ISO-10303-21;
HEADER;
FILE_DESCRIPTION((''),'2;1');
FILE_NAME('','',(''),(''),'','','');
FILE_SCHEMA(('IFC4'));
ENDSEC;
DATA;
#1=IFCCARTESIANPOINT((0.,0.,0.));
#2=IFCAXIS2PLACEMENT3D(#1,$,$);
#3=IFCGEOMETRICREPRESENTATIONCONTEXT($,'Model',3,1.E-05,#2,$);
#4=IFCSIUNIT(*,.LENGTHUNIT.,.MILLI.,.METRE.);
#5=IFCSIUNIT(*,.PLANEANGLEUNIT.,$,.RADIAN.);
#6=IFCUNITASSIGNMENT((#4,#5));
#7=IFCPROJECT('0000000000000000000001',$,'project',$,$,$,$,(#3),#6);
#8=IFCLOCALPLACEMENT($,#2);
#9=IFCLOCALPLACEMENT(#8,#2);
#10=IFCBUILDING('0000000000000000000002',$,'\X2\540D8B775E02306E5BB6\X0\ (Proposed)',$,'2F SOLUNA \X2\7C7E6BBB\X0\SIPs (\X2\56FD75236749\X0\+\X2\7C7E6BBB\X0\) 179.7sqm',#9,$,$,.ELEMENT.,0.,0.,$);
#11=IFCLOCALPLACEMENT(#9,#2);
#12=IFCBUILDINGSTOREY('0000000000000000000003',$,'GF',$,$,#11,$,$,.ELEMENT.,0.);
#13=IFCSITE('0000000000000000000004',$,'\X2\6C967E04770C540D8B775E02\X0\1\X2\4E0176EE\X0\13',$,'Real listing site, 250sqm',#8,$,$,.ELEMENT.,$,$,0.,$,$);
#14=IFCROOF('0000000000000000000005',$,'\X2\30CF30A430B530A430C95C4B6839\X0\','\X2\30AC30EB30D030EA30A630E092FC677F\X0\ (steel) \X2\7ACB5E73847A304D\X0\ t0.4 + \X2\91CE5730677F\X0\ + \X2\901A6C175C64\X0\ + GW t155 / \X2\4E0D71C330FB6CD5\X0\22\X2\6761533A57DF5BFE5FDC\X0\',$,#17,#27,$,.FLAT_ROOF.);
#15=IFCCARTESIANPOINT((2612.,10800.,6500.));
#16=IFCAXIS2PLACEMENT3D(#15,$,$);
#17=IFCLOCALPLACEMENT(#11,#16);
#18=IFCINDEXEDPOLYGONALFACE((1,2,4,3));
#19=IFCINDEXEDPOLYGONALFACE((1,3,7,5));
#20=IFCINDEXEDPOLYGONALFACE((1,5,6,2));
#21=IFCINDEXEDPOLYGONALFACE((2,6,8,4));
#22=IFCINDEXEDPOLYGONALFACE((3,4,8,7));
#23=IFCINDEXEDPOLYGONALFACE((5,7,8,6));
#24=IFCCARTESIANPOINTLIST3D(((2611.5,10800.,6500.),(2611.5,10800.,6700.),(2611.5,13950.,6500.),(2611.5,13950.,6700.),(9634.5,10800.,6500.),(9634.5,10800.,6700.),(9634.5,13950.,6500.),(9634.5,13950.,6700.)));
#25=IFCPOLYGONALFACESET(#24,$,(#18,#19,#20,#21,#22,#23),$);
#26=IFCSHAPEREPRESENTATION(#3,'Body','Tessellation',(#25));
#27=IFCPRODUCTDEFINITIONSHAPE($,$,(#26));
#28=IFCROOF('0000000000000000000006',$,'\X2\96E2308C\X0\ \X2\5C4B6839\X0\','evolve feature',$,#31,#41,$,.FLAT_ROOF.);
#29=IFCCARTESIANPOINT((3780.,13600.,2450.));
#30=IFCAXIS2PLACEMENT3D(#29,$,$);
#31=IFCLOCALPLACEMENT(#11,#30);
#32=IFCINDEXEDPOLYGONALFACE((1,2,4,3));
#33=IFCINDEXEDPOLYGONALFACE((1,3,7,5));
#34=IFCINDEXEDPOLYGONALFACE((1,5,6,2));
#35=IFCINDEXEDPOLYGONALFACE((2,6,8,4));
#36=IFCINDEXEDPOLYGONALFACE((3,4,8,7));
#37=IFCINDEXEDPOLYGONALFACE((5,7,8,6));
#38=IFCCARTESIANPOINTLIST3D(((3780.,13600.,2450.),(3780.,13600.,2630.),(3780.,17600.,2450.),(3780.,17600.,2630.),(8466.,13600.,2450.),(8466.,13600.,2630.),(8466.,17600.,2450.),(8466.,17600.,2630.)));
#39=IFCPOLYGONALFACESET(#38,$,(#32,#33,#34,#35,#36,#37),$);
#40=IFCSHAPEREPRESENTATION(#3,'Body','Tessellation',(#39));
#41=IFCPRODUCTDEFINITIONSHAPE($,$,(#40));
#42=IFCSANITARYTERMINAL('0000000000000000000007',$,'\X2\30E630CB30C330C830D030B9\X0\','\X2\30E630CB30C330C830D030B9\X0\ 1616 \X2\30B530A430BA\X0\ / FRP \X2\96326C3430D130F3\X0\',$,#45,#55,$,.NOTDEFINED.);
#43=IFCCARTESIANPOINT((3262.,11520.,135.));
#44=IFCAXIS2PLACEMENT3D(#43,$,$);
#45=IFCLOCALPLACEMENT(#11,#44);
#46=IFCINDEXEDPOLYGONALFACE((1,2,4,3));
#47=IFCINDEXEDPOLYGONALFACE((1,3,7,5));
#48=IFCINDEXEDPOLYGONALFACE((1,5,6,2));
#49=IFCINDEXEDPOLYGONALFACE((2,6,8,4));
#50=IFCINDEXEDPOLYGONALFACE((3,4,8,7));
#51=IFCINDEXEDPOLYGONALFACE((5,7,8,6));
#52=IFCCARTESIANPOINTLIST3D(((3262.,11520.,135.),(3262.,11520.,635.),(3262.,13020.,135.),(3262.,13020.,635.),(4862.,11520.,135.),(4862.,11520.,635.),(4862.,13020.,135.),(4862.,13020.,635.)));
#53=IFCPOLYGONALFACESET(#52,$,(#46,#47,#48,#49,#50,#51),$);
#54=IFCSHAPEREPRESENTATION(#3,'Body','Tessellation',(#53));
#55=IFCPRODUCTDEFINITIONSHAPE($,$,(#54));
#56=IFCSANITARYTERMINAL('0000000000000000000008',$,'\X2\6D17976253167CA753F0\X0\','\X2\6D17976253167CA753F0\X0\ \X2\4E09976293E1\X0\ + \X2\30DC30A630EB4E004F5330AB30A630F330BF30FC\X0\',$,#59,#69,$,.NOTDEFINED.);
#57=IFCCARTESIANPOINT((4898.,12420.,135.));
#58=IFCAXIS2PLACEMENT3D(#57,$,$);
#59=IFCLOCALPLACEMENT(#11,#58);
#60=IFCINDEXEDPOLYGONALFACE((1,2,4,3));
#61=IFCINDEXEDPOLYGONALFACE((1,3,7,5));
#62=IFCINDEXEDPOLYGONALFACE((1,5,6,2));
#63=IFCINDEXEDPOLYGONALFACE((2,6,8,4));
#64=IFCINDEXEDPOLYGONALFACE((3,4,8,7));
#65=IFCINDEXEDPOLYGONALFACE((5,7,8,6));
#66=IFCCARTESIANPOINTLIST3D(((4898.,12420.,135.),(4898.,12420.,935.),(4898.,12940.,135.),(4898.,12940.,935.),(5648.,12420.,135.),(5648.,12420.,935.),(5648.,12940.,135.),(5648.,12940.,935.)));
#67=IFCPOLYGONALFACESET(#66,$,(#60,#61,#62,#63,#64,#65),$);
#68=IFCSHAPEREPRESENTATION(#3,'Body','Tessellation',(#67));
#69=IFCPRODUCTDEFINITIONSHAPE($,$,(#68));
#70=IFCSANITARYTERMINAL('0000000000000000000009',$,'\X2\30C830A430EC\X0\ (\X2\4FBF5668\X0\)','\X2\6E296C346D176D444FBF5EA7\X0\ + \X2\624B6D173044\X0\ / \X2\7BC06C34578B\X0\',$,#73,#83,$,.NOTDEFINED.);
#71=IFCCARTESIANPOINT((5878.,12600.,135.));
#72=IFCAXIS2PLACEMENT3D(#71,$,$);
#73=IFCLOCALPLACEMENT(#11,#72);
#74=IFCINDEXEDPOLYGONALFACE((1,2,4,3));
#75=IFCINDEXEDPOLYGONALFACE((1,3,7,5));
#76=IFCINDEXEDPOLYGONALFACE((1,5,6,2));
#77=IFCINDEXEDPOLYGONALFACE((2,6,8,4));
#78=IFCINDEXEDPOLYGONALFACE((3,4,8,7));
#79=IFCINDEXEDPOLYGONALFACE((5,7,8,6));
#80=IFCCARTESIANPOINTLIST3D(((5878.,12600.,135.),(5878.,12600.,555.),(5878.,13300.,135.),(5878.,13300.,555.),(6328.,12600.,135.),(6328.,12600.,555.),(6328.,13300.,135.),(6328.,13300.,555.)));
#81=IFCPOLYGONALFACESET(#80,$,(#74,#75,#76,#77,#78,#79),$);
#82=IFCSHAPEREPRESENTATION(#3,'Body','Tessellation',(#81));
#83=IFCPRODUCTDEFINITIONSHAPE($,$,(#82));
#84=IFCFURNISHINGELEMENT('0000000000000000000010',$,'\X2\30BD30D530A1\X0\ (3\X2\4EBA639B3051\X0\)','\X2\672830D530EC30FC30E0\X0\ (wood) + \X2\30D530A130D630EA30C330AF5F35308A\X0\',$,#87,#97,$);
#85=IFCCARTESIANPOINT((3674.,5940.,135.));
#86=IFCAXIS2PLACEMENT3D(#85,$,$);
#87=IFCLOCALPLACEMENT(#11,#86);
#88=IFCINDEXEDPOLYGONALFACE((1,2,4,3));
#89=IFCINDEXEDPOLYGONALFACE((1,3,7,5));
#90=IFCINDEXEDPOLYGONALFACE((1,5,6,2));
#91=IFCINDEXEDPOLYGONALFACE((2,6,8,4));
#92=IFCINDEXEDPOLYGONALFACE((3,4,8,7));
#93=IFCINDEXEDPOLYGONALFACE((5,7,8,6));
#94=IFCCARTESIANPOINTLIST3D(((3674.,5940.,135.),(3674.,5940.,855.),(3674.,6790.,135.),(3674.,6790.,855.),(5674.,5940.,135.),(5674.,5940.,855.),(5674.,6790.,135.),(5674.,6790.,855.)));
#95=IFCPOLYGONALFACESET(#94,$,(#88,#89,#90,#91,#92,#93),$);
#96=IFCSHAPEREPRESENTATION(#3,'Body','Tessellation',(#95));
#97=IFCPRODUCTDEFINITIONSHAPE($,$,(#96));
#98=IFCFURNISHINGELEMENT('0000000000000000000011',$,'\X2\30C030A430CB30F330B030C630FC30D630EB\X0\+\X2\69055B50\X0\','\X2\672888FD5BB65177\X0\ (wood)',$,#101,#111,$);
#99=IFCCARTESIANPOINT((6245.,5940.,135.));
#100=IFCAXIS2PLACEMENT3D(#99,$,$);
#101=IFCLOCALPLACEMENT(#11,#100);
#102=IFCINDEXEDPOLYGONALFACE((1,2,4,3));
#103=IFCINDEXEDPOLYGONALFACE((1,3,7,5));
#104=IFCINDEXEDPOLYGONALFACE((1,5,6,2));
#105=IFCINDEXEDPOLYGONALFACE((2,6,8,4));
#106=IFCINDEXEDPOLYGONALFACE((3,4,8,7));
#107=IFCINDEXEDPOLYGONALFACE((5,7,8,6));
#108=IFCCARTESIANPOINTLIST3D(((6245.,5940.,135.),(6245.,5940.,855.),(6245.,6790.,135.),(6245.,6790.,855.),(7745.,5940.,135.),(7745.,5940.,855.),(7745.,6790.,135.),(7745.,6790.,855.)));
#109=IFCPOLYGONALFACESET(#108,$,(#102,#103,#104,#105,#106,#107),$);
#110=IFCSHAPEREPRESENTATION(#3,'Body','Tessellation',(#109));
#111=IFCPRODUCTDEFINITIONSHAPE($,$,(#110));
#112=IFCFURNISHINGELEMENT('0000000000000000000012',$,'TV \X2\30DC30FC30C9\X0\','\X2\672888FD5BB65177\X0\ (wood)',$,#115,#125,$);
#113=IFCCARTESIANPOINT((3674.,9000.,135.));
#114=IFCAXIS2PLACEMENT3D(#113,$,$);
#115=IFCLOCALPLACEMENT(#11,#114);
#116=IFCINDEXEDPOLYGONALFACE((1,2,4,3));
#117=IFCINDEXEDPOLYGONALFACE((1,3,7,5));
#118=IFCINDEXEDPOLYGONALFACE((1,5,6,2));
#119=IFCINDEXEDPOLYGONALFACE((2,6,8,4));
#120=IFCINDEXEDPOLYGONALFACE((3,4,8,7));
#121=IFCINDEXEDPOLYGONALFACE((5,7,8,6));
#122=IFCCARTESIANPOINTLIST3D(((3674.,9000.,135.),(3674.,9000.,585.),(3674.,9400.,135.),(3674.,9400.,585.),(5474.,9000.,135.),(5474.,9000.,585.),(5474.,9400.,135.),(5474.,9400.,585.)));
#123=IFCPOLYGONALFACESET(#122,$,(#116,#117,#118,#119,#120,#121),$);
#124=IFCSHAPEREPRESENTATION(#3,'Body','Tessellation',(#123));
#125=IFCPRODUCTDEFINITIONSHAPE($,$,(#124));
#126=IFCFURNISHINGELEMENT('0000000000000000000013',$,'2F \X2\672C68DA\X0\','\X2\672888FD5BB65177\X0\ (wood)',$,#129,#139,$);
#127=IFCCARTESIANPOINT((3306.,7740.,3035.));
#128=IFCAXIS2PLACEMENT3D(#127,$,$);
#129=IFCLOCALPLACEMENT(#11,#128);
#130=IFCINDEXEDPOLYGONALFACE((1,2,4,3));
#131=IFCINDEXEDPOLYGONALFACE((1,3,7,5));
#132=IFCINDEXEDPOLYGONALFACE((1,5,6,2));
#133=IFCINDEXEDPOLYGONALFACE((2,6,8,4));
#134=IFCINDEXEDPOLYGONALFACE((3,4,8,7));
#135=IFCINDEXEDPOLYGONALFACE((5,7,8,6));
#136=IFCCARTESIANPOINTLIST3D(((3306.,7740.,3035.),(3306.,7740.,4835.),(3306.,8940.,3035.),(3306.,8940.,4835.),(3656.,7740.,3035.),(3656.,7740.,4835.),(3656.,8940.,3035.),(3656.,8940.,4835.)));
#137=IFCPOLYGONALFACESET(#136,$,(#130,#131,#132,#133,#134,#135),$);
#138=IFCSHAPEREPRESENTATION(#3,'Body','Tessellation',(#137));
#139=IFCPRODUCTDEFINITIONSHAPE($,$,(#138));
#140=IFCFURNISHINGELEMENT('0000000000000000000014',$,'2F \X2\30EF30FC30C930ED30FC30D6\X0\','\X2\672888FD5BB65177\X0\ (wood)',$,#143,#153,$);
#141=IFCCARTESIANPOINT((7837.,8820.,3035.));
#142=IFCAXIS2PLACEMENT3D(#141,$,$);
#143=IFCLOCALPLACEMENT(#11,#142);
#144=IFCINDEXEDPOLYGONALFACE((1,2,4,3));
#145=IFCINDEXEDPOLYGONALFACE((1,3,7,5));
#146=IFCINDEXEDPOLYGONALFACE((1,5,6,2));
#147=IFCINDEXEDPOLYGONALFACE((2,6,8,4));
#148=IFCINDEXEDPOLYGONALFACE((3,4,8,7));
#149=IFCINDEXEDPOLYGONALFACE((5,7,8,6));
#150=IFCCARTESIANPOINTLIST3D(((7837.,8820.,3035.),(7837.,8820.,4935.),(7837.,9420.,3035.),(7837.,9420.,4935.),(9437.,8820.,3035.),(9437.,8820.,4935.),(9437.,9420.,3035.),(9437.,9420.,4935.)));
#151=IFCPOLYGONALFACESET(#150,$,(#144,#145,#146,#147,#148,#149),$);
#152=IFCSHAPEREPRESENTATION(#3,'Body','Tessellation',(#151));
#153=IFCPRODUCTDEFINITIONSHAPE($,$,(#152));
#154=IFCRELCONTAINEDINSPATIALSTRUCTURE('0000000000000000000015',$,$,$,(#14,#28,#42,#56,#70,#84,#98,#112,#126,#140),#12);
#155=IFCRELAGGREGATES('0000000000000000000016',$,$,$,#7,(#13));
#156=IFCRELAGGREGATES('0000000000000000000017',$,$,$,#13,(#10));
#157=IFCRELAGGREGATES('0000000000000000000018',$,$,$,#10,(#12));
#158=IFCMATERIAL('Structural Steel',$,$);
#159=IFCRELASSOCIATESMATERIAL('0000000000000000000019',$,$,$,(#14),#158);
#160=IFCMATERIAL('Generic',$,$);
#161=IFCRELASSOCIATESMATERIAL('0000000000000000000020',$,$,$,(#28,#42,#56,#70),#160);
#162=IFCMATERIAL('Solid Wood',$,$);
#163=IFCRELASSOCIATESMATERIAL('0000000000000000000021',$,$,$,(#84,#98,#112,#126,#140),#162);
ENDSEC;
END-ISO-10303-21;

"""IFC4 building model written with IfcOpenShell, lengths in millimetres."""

from ifc_helpers import new_model, si_unit, frame, frame_2d, origin, place, context, project, spatial, rectangle, extrude, material, element, save


model = new_model("IFC4")

# Units and contexts
model_context = context("Model", 3, precision=1e-05, world=origin())
ifc_project = project(units=[si_unit("LENGTHUNIT", "METRE", prefix="MILLI"), si_unit("PLANEANGLEUNIT", "RADIAN")], contexts=[model_context])

# Site, building, storey
site_placement = place(None, origin())
site = spatial("IfcSite", under=ifc_project, at=site_placement, Name="沖縄県名護市1丁目13", ObjectType="Real listing site, 250sqm", CompositionType="ELEMENT", RefElevation=0.0)
building_placement = place(site_placement, origin())
building = spatial("IfcBuilding", under=site, at=building_placement, Name="名護市の家 (Proposed)", ObjectType="2F SOLUNA 籾殻SIPs (国産杉+籾殻) 179.7sqm", CompositionType="ELEMENT", ElevationOfRefHeight=0.0, ElevationOfTerrain=0.0)
storey_placement = place(building_placement, origin())
storey = spatial("IfcBuildingStorey", under=building, at=storey_placement, Name="GF", CompositionType="ELEMENT", Elevation=0.0)

# Shared definitions
ifc_material_1 = material(Name="Generic")

# Shared definitions
ifc_material_2 = material(Name="Solid Wood")

# Roofs
ifc_material_3 = material(Name="Structural Steel")
roof_1_placement = place(storey_placement, frame((2612.0, 10800.0, 6500.0)))
element("IfcRoof", 1, at=roof_1_placement, inside=storey, material=ifc_material_3, Name="ハイサイド屋根", Description="ガルバリウム鋼板 (steel) 立平葺き t0.4 + 野地板 + 通気層 + GW t155 / 不燃・法22条区域対応", PredefinedType="FLAT_ROOF", context=model_context, shape_type="SweptSolid", body=[
    extrude(rectangle(XDim=7023.0, YDim=3150.0, at=frame_2d((3511.0, 1575.0))), frame((2612.0, 10800.0, 6500.0)), (0.0, 0.0, 1.0), 200.0),
])
roof_2_placement = place(storey_placement, frame((3780.0, 13600.0, 2450.0)))
element("IfcRoof", 2, at=roof_2_placement, inside=storey, material=ifc_material_1, Name="離れ 屋根", Description="evolve feature", PredefinedType="FLAT_ROOF", context=model_context, shape_type="SweptSolid", body=[
    extrude(rectangle(XDim=4686.0, YDim=4000.0, at=frame_2d((2343.0, 2000.0))), frame((3780.0, 13600.0, 2450.0)), (0.0, 0.0, 1.0), 180.0),
])

# Sanitary terminals
sanitary_terminal_1_placement = place(storey_placement, frame((3262.0, 11520.0, 135.0)))
element("IfcSanitaryTerminal", 3, at=sanitary_terminal_1_placement, inside=storey, material=ifc_material_1, Name="ユニットバス", Description="ユニットバス 1616 サイズ / FRP 防水パン", PredefinedType="NOTDEFINED", context=model_context, shape_type="SweptSolid", body=[
    extrude(rectangle(XDim=1600.0, YDim=1500.0, at=frame_2d((800.0, 750.0))), frame((3262.0, 11520.0, 135.0)), (0.0, 0.0, 1.0), 500.0),
])
sanitary_terminal_2_placement = place(storey_placement, frame((4898.0, 12420.0, 135.0)))
element("IfcSanitaryTerminal", 4, at=sanitary_terminal_2_placement, inside=storey, material=ifc_material_1, Name="洗面化粧台", Description="洗面化粧台 三面鏡 + ボウル一体カウンター", PredefinedType="NOTDEFINED", context=model_context, shape_type="SweptSolid", body=[
    extrude(rectangle(XDim=750.0, YDim=520.0, at=frame_2d((375.0, 260.0))), frame((4898.0, 12420.0, 135.0)), (0.0, 0.0, 1.0), 800.0),
])
sanitary_terminal_3_placement = place(storey_placement, frame((5878.0, 12600.0, 135.0)))
element("IfcSanitaryTerminal", 5, at=sanitary_terminal_3_placement, inside=storey, material=ifc_material_1, Name="トイレ (便器)", Description="温水洗浄便座 + 手洗い / 節水型", PredefinedType="NOTDEFINED", context=model_context, shape_type="SweptSolid", body=[
    extrude(rectangle(XDim=450.0, YDim=700.0, at=frame_2d((225.0, 350.0))), frame((5878.0, 12600.0, 135.0)), (0.0, 0.0, 1.0), 420.0),
])

# Furnishing elements
furnishing_1_placement = place(storey_placement, frame((3674.0, 5940.0, 135.0)))
element("IfcFurnishingElement", 6, at=furnishing_1_placement, inside=storey, material=ifc_material_2, Name="ソファ (3人掛け)", Description="木フレーム (wood) + ファブリック張り", context=model_context, shape_type="SweptSolid", body=[
    extrude(rectangle(XDim=2000.0, YDim=850.0, at=frame_2d((1000.0, 425.0))), frame((3674.0, 5940.0, 135.0)), (0.0, 0.0, 1.0), 720.0),
])
furnishing_2_placement = place(storey_placement, frame((6245.0, 5940.0, 135.0)))
element("IfcFurnishingElement", 7, at=furnishing_2_placement, inside=storey, material=ifc_material_2, Name="ダイニングテーブル+椅子", Description="木製家具 (wood)", context=model_context, shape_type="SweptSolid", body=[
    extrude(rectangle(XDim=1500.0, YDim=850.0, at=frame_2d((750.0, 425.0))), frame((6245.0, 5940.0, 135.0)), (0.0, 0.0, 1.0), 720.0),
])
furnishing_3_placement = place(storey_placement, frame((3674.0, 9000.0, 135.0)))
element("IfcFurnishingElement", 8, at=furnishing_3_placement, inside=storey, material=ifc_material_2, Name="TV ボード", Description="木製家具 (wood)", context=model_context, shape_type="SweptSolid", body=[
    extrude(rectangle(XDim=1800.0, YDim=400.0, at=frame_2d((900.0, 200.0))), frame((3674.0, 9000.0, 135.0)), (0.0, 0.0, 1.0), 450.0),
])
furnishing_4_placement = place(storey_placement, frame((3306.0, 7740.0, 3035.0)))
element("IfcFurnishingElement", 9, at=furnishing_4_placement, inside=storey, material=ifc_material_2, Name="2F 本棚", Description="木製家具 (wood)", context=model_context, shape_type="SweptSolid", body=[
    extrude(rectangle(XDim=350.0, YDim=1200.0, at=frame_2d((175.0, 600.0))), frame((3306.0, 7740.0, 3035.0)), (0.0, 0.0, 1.0), 1800.0),
])
furnishing_5_placement = place(storey_placement, frame((7837.0, 8820.0, 3035.0)))
element("IfcFurnishingElement", 10, at=furnishing_5_placement, inside=storey, material=ifc_material_2, Name="2F ワードローブ", Description="木製家具 (wood)", context=model_context, shape_type="SweptSolid", body=[
    extrude(rectangle(XDim=1600.0, YDim=600.0, at=frame_2d((800.0, 300.0))), frame((7837.0, 8820.0, 3035.0)), (0.0, 0.0, 1.0), 1900.0),
])

save(model, "model.ifc")
